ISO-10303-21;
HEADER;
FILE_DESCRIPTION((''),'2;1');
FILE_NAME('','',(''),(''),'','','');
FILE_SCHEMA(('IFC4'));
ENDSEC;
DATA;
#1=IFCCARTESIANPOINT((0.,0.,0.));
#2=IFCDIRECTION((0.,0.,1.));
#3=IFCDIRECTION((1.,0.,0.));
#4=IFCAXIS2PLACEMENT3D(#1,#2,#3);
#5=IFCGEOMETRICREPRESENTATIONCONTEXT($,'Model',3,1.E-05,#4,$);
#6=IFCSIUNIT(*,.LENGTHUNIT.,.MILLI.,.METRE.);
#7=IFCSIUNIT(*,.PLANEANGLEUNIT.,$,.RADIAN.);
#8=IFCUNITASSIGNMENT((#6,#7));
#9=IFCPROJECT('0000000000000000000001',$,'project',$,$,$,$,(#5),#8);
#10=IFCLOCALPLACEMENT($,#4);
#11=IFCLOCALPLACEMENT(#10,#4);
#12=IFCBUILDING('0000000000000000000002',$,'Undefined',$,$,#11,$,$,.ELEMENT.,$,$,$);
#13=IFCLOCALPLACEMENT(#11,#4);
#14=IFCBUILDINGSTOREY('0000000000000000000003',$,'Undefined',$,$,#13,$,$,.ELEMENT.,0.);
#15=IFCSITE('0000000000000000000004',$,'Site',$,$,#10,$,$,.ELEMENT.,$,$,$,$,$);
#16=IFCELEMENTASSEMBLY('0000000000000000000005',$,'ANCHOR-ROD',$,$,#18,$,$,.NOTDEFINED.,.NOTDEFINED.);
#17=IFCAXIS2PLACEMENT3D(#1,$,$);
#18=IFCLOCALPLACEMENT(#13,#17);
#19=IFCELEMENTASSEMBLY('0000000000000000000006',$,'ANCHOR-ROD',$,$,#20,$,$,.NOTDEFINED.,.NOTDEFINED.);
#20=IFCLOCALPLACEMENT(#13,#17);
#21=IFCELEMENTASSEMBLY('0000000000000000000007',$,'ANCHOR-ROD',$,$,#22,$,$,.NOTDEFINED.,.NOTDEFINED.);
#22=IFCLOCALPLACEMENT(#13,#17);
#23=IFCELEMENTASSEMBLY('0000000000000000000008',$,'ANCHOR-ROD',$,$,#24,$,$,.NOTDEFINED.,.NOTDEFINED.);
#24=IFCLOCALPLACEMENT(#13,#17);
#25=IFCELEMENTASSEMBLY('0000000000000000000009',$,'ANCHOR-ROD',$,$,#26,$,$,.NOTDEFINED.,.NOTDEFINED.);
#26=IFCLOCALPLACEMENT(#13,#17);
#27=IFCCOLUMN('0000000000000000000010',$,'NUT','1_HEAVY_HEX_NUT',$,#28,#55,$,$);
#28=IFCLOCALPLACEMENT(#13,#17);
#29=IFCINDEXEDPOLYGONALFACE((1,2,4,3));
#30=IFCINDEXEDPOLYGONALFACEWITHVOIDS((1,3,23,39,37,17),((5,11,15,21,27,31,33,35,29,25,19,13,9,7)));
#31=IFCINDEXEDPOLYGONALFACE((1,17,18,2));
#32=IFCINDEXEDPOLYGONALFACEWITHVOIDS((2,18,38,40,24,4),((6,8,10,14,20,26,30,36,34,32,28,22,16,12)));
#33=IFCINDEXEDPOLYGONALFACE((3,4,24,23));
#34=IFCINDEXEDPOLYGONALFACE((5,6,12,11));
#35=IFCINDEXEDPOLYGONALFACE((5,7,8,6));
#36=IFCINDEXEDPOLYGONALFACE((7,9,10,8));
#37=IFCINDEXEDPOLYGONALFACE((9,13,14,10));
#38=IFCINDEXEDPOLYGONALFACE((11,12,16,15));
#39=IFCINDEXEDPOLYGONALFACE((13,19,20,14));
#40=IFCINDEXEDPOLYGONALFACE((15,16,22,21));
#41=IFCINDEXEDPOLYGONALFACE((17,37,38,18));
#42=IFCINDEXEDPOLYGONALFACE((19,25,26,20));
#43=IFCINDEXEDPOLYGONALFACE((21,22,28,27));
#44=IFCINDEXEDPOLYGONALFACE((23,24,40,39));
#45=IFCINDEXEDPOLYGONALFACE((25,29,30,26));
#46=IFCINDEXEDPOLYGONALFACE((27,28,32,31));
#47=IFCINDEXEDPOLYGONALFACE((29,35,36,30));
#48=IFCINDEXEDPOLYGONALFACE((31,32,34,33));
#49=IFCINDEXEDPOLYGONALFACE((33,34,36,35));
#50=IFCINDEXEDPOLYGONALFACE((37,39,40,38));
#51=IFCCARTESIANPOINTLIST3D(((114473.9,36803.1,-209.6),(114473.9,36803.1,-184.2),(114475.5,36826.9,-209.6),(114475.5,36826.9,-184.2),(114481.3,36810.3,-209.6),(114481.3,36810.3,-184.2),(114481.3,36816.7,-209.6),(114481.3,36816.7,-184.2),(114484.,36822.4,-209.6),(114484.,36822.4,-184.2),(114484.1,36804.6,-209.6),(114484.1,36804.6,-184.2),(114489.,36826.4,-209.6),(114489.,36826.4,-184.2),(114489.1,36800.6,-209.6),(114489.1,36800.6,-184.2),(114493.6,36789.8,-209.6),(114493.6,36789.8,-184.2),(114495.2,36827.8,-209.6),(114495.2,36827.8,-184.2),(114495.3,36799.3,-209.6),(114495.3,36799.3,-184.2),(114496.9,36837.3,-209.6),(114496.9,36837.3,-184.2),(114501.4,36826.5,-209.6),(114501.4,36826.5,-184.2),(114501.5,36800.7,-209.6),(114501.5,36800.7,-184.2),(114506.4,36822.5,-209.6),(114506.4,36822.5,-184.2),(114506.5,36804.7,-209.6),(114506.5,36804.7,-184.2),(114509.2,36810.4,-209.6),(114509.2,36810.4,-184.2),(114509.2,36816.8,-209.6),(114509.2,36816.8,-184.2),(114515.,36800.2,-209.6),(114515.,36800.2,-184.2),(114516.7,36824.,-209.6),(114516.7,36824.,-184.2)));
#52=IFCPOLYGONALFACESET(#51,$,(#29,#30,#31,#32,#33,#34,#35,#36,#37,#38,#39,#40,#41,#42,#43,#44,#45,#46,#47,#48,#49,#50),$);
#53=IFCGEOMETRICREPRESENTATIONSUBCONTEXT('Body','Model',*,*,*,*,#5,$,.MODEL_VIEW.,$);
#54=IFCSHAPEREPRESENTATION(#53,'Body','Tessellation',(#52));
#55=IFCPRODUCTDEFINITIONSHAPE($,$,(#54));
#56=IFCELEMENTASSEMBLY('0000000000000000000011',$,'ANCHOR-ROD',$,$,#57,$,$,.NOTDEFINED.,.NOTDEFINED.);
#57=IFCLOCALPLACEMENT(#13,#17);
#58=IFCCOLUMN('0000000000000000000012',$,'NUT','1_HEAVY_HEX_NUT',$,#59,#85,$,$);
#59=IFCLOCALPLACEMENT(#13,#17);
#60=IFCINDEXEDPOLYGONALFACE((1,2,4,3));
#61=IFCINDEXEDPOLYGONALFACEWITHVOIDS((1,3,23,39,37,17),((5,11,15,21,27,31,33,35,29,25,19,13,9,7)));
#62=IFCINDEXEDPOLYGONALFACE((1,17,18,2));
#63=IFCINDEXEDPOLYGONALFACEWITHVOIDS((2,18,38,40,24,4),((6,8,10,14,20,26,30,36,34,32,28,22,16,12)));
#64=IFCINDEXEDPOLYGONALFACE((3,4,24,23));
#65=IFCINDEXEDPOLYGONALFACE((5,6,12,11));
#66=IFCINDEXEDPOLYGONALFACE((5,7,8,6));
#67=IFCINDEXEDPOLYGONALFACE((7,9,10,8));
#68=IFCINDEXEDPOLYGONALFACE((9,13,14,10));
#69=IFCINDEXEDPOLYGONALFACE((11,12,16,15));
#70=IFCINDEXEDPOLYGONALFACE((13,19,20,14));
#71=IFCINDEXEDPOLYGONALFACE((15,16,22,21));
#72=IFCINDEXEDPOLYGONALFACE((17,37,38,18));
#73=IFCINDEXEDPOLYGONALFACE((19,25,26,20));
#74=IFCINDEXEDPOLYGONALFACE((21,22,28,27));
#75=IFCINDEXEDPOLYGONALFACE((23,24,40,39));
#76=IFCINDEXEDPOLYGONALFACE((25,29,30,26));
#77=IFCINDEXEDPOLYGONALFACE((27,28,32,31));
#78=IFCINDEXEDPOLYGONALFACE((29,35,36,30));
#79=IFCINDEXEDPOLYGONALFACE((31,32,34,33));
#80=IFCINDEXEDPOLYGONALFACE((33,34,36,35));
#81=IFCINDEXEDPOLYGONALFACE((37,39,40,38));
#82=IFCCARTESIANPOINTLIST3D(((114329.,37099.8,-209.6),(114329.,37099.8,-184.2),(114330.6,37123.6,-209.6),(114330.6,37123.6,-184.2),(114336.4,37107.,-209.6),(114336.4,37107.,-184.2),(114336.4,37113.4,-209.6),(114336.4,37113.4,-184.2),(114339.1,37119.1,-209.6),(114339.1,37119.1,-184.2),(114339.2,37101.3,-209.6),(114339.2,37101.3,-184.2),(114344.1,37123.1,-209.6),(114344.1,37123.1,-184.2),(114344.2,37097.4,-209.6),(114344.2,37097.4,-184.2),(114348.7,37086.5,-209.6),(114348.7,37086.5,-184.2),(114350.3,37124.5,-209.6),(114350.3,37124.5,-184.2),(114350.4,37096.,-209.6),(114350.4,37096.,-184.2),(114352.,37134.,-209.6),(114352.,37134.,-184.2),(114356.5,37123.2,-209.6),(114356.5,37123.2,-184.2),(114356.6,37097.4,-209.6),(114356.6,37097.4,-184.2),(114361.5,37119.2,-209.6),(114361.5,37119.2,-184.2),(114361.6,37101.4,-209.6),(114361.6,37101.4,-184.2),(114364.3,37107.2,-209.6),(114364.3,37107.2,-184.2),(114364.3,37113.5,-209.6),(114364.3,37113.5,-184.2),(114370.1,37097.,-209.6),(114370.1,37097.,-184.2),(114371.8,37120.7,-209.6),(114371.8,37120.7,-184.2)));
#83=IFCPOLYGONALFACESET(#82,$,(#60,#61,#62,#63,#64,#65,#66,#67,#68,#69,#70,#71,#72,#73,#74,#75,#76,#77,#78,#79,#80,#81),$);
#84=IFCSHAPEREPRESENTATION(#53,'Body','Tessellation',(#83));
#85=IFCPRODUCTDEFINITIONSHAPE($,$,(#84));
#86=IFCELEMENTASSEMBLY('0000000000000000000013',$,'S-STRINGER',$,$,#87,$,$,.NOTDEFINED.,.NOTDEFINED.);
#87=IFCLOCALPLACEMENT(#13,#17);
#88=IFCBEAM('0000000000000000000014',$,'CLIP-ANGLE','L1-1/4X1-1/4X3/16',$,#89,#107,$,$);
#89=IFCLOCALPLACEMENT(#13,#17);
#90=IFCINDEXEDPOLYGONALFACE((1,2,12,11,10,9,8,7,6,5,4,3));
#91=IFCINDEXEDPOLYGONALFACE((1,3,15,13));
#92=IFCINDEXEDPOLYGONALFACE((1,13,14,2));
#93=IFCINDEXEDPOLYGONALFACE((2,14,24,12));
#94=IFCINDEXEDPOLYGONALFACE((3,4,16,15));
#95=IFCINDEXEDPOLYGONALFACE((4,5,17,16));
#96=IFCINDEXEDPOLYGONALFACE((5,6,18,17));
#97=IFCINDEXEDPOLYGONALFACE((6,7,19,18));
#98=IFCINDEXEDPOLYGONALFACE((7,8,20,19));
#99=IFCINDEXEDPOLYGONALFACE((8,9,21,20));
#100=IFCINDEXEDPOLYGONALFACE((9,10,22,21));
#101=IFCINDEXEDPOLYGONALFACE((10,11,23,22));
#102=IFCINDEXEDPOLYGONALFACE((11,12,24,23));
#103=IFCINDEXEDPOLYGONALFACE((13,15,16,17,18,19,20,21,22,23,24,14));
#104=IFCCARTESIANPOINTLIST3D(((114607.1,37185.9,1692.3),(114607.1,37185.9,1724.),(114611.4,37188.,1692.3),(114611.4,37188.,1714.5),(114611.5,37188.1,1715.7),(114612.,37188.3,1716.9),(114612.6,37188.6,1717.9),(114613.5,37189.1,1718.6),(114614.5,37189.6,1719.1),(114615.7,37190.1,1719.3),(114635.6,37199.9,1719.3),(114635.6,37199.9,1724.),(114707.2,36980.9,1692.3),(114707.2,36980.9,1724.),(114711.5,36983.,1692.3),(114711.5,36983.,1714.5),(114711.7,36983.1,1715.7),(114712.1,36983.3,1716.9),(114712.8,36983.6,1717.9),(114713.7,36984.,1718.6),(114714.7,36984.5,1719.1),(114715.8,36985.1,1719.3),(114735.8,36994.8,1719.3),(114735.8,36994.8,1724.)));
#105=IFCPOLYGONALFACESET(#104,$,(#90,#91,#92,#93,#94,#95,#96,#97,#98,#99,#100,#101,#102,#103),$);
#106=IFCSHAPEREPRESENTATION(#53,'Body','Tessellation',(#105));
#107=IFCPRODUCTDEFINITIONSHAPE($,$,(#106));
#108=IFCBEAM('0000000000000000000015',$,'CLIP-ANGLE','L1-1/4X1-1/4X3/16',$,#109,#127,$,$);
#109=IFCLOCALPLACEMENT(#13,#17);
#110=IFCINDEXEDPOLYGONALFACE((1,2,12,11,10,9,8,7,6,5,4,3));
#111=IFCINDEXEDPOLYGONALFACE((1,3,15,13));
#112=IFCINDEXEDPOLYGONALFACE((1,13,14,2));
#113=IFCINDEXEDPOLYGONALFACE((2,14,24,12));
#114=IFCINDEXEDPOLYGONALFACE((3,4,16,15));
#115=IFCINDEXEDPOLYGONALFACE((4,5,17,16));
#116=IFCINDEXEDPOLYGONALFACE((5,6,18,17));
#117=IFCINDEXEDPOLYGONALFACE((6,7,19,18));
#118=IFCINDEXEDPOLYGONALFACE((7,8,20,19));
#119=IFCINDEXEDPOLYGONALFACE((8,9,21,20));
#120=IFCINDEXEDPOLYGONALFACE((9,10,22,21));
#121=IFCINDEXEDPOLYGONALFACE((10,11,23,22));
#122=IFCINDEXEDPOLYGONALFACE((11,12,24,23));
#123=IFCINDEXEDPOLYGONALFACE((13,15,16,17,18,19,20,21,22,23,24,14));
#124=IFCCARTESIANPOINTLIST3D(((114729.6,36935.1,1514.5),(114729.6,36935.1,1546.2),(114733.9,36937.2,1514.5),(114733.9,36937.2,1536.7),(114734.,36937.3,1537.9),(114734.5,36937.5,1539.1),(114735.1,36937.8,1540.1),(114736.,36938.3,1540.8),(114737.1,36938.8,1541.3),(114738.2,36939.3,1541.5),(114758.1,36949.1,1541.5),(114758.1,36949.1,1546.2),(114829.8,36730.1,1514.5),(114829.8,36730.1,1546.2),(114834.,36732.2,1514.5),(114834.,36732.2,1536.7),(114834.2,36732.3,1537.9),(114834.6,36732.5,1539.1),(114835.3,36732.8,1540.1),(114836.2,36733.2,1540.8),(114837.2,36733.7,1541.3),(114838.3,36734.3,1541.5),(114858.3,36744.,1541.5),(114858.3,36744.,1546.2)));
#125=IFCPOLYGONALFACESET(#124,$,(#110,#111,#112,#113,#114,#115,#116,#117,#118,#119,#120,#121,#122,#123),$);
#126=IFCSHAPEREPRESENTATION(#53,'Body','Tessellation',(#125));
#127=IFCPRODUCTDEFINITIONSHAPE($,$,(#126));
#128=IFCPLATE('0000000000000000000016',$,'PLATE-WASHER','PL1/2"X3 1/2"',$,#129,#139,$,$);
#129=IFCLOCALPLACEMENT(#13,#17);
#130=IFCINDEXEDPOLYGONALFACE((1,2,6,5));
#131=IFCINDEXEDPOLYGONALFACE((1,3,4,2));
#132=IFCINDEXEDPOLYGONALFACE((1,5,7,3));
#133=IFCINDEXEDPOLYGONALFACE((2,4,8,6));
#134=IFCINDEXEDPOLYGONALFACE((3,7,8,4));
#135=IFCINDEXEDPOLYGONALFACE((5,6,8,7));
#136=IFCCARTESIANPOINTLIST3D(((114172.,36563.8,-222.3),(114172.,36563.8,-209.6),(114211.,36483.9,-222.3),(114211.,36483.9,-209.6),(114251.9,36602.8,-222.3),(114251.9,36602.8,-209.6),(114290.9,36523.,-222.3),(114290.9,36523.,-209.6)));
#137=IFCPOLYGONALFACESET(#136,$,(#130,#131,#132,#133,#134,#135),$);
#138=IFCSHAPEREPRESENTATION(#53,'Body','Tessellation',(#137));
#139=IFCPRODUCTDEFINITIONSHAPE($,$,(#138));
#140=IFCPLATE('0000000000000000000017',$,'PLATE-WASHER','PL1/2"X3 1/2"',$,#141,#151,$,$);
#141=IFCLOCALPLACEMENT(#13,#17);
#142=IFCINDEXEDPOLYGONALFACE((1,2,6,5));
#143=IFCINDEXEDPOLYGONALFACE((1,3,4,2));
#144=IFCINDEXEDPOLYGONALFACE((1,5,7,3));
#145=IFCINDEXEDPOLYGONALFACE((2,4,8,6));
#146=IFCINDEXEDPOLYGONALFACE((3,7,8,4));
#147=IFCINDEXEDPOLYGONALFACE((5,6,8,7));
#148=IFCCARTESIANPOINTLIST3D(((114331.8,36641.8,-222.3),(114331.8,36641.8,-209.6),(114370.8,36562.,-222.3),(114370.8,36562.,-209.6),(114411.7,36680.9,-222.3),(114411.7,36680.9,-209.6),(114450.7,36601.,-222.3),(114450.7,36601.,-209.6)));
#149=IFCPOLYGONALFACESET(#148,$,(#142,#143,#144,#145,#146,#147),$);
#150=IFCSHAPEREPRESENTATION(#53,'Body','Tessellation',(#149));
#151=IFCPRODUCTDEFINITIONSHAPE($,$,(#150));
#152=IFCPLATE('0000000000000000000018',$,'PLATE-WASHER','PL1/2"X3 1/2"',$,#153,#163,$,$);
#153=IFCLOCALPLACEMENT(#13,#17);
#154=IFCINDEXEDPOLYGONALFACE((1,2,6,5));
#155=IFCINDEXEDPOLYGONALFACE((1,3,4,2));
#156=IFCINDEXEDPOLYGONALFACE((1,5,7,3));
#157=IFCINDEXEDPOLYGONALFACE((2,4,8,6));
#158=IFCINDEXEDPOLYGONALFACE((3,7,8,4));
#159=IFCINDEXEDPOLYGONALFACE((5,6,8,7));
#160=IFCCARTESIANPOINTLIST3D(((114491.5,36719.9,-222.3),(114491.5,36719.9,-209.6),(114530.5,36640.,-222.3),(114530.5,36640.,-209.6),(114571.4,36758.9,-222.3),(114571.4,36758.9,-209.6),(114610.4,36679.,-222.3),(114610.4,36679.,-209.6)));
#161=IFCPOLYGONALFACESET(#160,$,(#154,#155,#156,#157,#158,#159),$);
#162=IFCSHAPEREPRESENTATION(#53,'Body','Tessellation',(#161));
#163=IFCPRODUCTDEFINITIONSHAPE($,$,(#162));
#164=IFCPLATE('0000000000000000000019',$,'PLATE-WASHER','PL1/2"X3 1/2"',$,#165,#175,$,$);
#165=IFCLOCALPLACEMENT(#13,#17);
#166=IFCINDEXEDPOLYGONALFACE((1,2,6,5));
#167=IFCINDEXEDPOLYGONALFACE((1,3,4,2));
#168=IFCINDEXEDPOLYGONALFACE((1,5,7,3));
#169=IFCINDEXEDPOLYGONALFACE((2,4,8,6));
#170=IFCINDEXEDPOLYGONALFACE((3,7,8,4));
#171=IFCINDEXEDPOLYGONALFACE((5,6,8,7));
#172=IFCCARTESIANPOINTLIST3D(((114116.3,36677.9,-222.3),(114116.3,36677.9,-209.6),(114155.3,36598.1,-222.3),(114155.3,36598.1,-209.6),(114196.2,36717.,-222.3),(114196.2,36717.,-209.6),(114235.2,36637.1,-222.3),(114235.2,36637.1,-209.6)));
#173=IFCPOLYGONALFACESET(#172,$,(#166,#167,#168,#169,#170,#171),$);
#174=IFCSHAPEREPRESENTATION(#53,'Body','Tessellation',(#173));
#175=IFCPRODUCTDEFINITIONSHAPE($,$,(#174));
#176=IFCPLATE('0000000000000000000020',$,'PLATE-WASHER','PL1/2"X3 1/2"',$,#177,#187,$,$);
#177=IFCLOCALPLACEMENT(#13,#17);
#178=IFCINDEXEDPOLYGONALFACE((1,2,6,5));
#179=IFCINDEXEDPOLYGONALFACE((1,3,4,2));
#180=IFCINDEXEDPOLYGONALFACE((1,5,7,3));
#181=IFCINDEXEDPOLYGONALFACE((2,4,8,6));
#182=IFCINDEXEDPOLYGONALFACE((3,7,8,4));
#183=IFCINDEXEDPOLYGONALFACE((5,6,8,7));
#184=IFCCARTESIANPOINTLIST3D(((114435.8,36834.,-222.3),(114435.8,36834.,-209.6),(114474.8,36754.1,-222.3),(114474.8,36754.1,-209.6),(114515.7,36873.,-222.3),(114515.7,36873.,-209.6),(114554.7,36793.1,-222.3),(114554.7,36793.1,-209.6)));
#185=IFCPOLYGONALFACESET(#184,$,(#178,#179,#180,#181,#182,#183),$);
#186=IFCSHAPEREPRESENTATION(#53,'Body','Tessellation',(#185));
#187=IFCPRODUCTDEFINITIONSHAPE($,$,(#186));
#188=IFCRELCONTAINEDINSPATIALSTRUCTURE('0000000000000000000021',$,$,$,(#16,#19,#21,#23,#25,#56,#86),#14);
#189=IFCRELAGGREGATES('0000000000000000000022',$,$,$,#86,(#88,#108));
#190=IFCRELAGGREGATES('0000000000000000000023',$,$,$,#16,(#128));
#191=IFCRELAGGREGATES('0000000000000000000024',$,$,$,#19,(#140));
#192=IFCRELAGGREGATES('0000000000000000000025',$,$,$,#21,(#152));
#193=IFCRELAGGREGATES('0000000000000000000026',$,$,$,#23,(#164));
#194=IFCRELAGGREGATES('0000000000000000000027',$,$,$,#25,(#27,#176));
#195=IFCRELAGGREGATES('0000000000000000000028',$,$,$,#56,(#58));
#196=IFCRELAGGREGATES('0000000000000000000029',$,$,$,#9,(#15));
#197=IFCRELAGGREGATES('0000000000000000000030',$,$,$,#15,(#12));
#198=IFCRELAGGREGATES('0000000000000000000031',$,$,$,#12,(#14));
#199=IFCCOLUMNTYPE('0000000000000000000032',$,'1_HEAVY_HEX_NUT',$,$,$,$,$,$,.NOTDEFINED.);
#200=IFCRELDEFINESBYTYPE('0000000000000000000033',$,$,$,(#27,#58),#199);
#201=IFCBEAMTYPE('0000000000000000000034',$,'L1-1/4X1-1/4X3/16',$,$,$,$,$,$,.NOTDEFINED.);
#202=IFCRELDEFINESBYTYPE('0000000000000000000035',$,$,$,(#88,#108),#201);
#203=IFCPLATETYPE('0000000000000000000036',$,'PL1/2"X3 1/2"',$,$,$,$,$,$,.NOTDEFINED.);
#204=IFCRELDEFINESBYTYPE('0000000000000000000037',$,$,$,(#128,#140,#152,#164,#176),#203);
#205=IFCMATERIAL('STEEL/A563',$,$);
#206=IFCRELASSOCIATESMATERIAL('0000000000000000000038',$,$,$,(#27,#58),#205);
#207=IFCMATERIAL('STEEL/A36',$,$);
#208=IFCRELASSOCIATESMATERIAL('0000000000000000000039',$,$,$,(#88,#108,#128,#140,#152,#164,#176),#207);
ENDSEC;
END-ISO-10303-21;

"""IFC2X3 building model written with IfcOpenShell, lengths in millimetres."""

from ifc_helpers import new_model, si_unit, frame, origin_with_axes, origin_2d_with_axis, place, context, subcontext, project, spatial, polyline, l_section, outline, extrude, material, type_object, element, aggregate, save


model = new_model("IFC2X3")

# Units and contexts
model_context = context("Model", 3, precision=1e-05, world=origin_with_axes())
body_context = subcontext(model_context, "Body", "Model", "MODEL_VIEW")
ifc_project = project(units=[si_unit("LENGTHUNIT", "METRE", prefix="MILLI"), si_unit("PLANEANGLEUNIT", "RADIAN")], contexts=[model_context])

# Site, building, storey
site_placement = place(None, origin_with_axes())
site = spatial("IfcSite", under=ifc_project, at=site_placement, Name="Site", CompositionType="ELEMENT")
building_placement = place(site_placement, origin_with_axes())
building = spatial("IfcBuilding", under=site, at=building_placement, Name="Undefined", CompositionType="ELEMENT")
storey_placement = place(building_placement, origin_with_axes())
storey = spatial("IfcBuildingStorey", under=building, at=storey_placement, Name="Undefined", CompositionType="ELEMENT", Elevation=0.0)

# Element assemblies, columns
assembly_1_placement = place(storey_placement, origin_with_axes())
assembly_1 = element("IfcElementAssembly", 1, at=assembly_1_placement, inside=storey, Name="ANCHOR-ROD", AssemblyPlace="NOTDEFINED", PredefinedType="NOTDEFINED")
ifc_material_1 = material(Name="STEEL/A563")
column_type_1 = type_object("IfcColumnType", Name="1_HEAVY_HEX_NUT", PredefinedType="NOTDEFINED")
assembly_2_placement = place(storey_placement, origin_with_axes())
assembly_2 = element("IfcElementAssembly", 2, at=assembly_2_placement, inside=storey, Name="ANCHOR-ROD", AssemblyPlace="NOTDEFINED", PredefinedType="NOTDEFINED")
assembly_3_placement = place(storey_placement, origin_with_axes())
assembly_3 = element("IfcElementAssembly", 3, at=assembly_3_placement, inside=storey, Name="ANCHOR-ROD", AssemblyPlace="NOTDEFINED", PredefinedType="NOTDEFINED")
assembly_4_placement = place(storey_placement, origin_with_axes())
assembly_4 = element("IfcElementAssembly", 4, at=assembly_4_placement, inside=storey, Name="ANCHOR-ROD", AssemblyPlace="NOTDEFINED", PredefinedType="NOTDEFINED")
assembly_5_placement = place(storey_placement, origin_with_axes())
assembly_5 = element("IfcElementAssembly", 5, at=assembly_5_placement, inside=storey, Name="ANCHOR-ROD", AssemblyPlace="NOTDEFINED", PredefinedType="NOTDEFINED")
column_1_placement = place(assembly_5_placement, frame((114495.3, 36813.5, -184.2), z_axis=(0.0, 0.0, -1.0), x_axis=(-0.438807, 0.898581, 0.0)))
column_1 = element("IfcColumn", 6, at=column_1_placement, type_object=column_type_1, material=ifc_material_1, Name="NUT", Description="1_HEAVY_HEX_NUT", context=body_context, shape_type="SweptSolid", body=[
    extrude(outline(polyline([(-11.9, -20.6), (-23.8, 0.0), (-11.9, 20.6), (11.9, 20.6), (23.8, 0.0), (11.9, -20.6), (-11.9, -20.6)]), holes=[polyline([(11.2, 8.9), (6.2, 12.9), (0.0, 14.3), (-6.2, 12.9), (-11.2, 8.9), (-13.9, 3.2), (-13.9, -3.2), (-11.2, -8.9), (-6.2, -12.9), (0.0, -14.3), (6.2, -12.9), (11.2, -8.9), (13.9, -3.2), (13.9, 3.2), (11.2, 8.9)])]), frame((0.0, 0.0, 25.4), z_axis=(0.0, 0.0, -1.0), x_axis=(0.0, 1.0, 0.0)), (0.0, 0.0, 1.0), 25.4),
])
assembly_6_placement = place(storey_placement, origin_with_axes())
assembly_6 = element("IfcElementAssembly", 7, at=assembly_6_placement, inside=storey, Name="ANCHOR-ROD", AssemblyPlace="NOTDEFINED", PredefinedType="NOTDEFINED")
column_2_placement = place(assembly_6_placement, frame((114350.4, 37110.3, -184.2), z_axis=(0.0, 0.0, -1.0), x_axis=(-0.438807, 0.898581, 0.0)))
column_2 = element("IfcColumn", 8, at=column_2_placement, type_object=column_type_1, material=ifc_material_1, Name="NUT", Description="1_HEAVY_HEX_NUT", context=body_context, shape_type="SweptSolid", body=[
    extrude(outline(polyline([(-11.9, -20.6), (-23.8, 0.0), (-11.9, 20.6), (11.9, 20.6), (23.8, 0.0), (11.9, -20.6), (-11.9, -20.6)]), holes=[polyline([(11.2, 8.9), (6.2, 12.9), (0.0, 14.3), (-6.2, 12.9), (-11.2, 8.9), (-13.9, 3.2), (-13.9, -3.2), (-11.2, -8.9), (-6.2, -12.9), (0.0, -14.3), (6.2, -12.9), (11.2, -8.9), (13.9, -3.2), (13.9, 3.2), (11.2, 8.9)])]), frame((0.0, 0.0, 25.4), z_axis=(0.0, 0.0, -1.0), x_axis=(0.0, 1.0, 0.0)), (0.0, 0.0, 1.0), 25.4),
])

# Element assembly, beams
assembly_7_placement = place(storey_placement, origin_with_axes())
assembly_7 = element("IfcElementAssembly", 9, at=assembly_7_placement, inside=storey, Name="S-STRINGER", AssemblyPlace="NOTDEFINED", PredefinedType="NOTDEFINED")
ifc_material_2 = material(Name="STEEL/A36")
beam_type = type_object("IfcBeamType", Name="L1-1/4X1-1/4X3/16", PredefinedType="NOTDEFINED")
beam_1_placement = place(assembly_7_placement, frame((114721.5, 36987.9, 1708.1), z_axis=(0.898531, 0.438909, 0.0), x_axis=(-0.438909, 0.898531, 0.0)))
beam_1 = element("IfcBeam", 10, at=beam_1_placement, type_object=beam_type, material=ifc_material_2, Name="CLIP-ANGLE", Description="L1-1/4X1-1/4X3/16", context=body_context, shape_type="SweptSolid", body=[
    extrude(l_section(Depth=31.8, Width=31.8, Thickness=4.8, FilletRadius=4.8, at=origin_2d_with_axis()), frame((228.2, 0.0, 0.0), z_axis=(-1.0, 0.0, 0.0), x_axis=(0.0, -1.0, 0.0)), (0.0, 0.0, 1.0), 228.2),
])
beam_2_placement = place(assembly_7_placement, frame((114844.0, 36737.1, 1530.3), z_axis=(0.898531, 0.438909, 0.0), x_axis=(-0.438909, 0.898531, 0.0)))
beam_2 = element("IfcBeam", 11, at=beam_2_placement, type_object=beam_type, material=ifc_material_2, Name="CLIP-ANGLE", Description="L1-1/4X1-1/4X3/16", context=body_context, shape_type="SweptSolid", body=[
    extrude(l_section(Depth=31.8, Width=31.8, Thickness=4.8, FilletRadius=4.8, at=origin_2d_with_axis()), frame((228.2, 0.0, 0.0), z_axis=(-1.0, 0.0, 0.0), x_axis=(0.0, -1.0, 0.0)), (0.0, 0.0, 1.0), 228.2),
])
aggregate(assembly_7, [beam_1, beam_2])

# Plates
plate_type = type_object("IfcPlateType", Name="PL1/2\"X3 1/2\"", PredefinedType="NOTDEFINED")
plate_1_placement = place(assembly_1_placement, frame((114251.9, 36602.8, -215.9), z_axis=(0.0, 0.0, -1.0), x_axis=(0.438807, -0.898581, 0.0)))
plate_1 = element("IfcPlate", 12, at=plate_1_placement, type_object=plate_type, material=ifc_material_2, Name="PLATE-WASHER", Description="PL1/2\"X3 1/2\"", context=body_context, shape_type="SweptSolid", body=[
    extrude(outline(polyline([(0.0, 0.0), (88.9, 0.0), (88.9, 88.9), (0.0, 88.9), (0.0, 0.0)])), frame((0.0, 0.0, -6.3), z_axis=(0.0, 0.0, 1.0), x_axis=(1.0, 0.0, 0.0)), (0.0, 0.0, 1.0), 12.7),
])
plate_2_placement = place(assembly_2_placement, frame((114411.7, 36680.9, -215.9), z_axis=(0.0, 0.0, -1.0), x_axis=(0.438807, -0.898581, 0.0)))
plate_2 = element("IfcPlate", 13, at=plate_2_placement, type_object=plate_type, material=ifc_material_2, Name="PLATE-WASHER", Description="PL1/2\"X3 1/2\"", context=body_context, shape_type="SweptSolid", body=[
    extrude(outline(polyline([(0.0, 0.0), (88.9, 0.0), (88.9, 88.9), (0.0, 88.9), (0.0, 0.0)])), frame((0.0, 0.0, -6.3), z_axis=(0.0, 0.0, 1.0), x_axis=(1.0, 0.0, 0.0)), (0.0, 0.0, 1.0), 12.7),
])
plate_3_placement = place(assembly_3_placement, frame((114571.4, 36758.9, -215.9), z_axis=(0.0, 0.0, -1.0), x_axis=(0.438807, -0.898581, 0.0)))
plate_3 = element("IfcPlate", 14, at=plate_3_placement, type_object=plate_type, material=ifc_material_2, Name="PLATE-WASHER", Description="PL1/2\"X3 1/2\"", context=body_context, shape_type="SweptSolid", body=[
    extrude(outline(polyline([(0.0, 0.0), (88.9, 0.0), (88.9, 88.9), (0.0, 88.9), (0.0, 0.0)])), frame((0.0, 0.0, -6.3), z_axis=(0.0, 0.0, 1.0), x_axis=(1.0, 0.0, 0.0)), (0.0, 0.0, 1.0), 12.7),
])
plate_4_placement = place(assembly_4_placement, frame((114196.2, 36717.0, -215.9), z_axis=(0.0, 0.0, -1.0), x_axis=(0.438807, -0.898581, 0.0)))
plate_4 = element("IfcPlate", 15, at=plate_4_placement, type_object=plate_type, material=ifc_material_2, Name="PLATE-WASHER", Description="PL1/2\"X3 1/2\"", context=body_context, shape_type="SweptSolid", body=[
    extrude(outline(polyline([(0.0, 0.0), (88.9, 0.0), (88.9, 88.9), (0.0, 88.9), (0.0, 0.0)])), frame((0.0, 0.0, -6.3), z_axis=(0.0, 0.0, 1.0), x_axis=(1.0, 0.0, 0.0)), (0.0, 0.0, 1.0), 12.7),
])
plate_5_placement = place(assembly_5_placement, frame((114515.7, 36873.0, -215.9), z_axis=(0.0, 0.0, -1.0), x_axis=(0.438807, -0.898581, 0.0)))
plate_5 = element("IfcPlate", 16, at=plate_5_placement, type_object=plate_type, material=ifc_material_2, Name="PLATE-WASHER", Description="PL1/2\"X3 1/2\"", context=body_context, shape_type="SweptSolid", body=[
    extrude(outline(polyline([(0.0, 0.0), (88.9, 0.0), (88.9, 88.9), (0.0, 88.9), (0.0, 0.0)])), frame((0.0, 0.0, -6.3), z_axis=(0.0, 0.0, 1.0), x_axis=(1.0, 0.0, 0.0)), (0.0, 0.0, 1.0), 12.7),
])

aggregate(assembly_1, [plate_1])
aggregate(assembly_2, [plate_2])
aggregate(assembly_3, [plate_3])
aggregate(assembly_4, [plate_4])
aggregate(assembly_5, [column_1, plate_5])
aggregate(assembly_6, [column_2])

save(model, "model.ifc")
